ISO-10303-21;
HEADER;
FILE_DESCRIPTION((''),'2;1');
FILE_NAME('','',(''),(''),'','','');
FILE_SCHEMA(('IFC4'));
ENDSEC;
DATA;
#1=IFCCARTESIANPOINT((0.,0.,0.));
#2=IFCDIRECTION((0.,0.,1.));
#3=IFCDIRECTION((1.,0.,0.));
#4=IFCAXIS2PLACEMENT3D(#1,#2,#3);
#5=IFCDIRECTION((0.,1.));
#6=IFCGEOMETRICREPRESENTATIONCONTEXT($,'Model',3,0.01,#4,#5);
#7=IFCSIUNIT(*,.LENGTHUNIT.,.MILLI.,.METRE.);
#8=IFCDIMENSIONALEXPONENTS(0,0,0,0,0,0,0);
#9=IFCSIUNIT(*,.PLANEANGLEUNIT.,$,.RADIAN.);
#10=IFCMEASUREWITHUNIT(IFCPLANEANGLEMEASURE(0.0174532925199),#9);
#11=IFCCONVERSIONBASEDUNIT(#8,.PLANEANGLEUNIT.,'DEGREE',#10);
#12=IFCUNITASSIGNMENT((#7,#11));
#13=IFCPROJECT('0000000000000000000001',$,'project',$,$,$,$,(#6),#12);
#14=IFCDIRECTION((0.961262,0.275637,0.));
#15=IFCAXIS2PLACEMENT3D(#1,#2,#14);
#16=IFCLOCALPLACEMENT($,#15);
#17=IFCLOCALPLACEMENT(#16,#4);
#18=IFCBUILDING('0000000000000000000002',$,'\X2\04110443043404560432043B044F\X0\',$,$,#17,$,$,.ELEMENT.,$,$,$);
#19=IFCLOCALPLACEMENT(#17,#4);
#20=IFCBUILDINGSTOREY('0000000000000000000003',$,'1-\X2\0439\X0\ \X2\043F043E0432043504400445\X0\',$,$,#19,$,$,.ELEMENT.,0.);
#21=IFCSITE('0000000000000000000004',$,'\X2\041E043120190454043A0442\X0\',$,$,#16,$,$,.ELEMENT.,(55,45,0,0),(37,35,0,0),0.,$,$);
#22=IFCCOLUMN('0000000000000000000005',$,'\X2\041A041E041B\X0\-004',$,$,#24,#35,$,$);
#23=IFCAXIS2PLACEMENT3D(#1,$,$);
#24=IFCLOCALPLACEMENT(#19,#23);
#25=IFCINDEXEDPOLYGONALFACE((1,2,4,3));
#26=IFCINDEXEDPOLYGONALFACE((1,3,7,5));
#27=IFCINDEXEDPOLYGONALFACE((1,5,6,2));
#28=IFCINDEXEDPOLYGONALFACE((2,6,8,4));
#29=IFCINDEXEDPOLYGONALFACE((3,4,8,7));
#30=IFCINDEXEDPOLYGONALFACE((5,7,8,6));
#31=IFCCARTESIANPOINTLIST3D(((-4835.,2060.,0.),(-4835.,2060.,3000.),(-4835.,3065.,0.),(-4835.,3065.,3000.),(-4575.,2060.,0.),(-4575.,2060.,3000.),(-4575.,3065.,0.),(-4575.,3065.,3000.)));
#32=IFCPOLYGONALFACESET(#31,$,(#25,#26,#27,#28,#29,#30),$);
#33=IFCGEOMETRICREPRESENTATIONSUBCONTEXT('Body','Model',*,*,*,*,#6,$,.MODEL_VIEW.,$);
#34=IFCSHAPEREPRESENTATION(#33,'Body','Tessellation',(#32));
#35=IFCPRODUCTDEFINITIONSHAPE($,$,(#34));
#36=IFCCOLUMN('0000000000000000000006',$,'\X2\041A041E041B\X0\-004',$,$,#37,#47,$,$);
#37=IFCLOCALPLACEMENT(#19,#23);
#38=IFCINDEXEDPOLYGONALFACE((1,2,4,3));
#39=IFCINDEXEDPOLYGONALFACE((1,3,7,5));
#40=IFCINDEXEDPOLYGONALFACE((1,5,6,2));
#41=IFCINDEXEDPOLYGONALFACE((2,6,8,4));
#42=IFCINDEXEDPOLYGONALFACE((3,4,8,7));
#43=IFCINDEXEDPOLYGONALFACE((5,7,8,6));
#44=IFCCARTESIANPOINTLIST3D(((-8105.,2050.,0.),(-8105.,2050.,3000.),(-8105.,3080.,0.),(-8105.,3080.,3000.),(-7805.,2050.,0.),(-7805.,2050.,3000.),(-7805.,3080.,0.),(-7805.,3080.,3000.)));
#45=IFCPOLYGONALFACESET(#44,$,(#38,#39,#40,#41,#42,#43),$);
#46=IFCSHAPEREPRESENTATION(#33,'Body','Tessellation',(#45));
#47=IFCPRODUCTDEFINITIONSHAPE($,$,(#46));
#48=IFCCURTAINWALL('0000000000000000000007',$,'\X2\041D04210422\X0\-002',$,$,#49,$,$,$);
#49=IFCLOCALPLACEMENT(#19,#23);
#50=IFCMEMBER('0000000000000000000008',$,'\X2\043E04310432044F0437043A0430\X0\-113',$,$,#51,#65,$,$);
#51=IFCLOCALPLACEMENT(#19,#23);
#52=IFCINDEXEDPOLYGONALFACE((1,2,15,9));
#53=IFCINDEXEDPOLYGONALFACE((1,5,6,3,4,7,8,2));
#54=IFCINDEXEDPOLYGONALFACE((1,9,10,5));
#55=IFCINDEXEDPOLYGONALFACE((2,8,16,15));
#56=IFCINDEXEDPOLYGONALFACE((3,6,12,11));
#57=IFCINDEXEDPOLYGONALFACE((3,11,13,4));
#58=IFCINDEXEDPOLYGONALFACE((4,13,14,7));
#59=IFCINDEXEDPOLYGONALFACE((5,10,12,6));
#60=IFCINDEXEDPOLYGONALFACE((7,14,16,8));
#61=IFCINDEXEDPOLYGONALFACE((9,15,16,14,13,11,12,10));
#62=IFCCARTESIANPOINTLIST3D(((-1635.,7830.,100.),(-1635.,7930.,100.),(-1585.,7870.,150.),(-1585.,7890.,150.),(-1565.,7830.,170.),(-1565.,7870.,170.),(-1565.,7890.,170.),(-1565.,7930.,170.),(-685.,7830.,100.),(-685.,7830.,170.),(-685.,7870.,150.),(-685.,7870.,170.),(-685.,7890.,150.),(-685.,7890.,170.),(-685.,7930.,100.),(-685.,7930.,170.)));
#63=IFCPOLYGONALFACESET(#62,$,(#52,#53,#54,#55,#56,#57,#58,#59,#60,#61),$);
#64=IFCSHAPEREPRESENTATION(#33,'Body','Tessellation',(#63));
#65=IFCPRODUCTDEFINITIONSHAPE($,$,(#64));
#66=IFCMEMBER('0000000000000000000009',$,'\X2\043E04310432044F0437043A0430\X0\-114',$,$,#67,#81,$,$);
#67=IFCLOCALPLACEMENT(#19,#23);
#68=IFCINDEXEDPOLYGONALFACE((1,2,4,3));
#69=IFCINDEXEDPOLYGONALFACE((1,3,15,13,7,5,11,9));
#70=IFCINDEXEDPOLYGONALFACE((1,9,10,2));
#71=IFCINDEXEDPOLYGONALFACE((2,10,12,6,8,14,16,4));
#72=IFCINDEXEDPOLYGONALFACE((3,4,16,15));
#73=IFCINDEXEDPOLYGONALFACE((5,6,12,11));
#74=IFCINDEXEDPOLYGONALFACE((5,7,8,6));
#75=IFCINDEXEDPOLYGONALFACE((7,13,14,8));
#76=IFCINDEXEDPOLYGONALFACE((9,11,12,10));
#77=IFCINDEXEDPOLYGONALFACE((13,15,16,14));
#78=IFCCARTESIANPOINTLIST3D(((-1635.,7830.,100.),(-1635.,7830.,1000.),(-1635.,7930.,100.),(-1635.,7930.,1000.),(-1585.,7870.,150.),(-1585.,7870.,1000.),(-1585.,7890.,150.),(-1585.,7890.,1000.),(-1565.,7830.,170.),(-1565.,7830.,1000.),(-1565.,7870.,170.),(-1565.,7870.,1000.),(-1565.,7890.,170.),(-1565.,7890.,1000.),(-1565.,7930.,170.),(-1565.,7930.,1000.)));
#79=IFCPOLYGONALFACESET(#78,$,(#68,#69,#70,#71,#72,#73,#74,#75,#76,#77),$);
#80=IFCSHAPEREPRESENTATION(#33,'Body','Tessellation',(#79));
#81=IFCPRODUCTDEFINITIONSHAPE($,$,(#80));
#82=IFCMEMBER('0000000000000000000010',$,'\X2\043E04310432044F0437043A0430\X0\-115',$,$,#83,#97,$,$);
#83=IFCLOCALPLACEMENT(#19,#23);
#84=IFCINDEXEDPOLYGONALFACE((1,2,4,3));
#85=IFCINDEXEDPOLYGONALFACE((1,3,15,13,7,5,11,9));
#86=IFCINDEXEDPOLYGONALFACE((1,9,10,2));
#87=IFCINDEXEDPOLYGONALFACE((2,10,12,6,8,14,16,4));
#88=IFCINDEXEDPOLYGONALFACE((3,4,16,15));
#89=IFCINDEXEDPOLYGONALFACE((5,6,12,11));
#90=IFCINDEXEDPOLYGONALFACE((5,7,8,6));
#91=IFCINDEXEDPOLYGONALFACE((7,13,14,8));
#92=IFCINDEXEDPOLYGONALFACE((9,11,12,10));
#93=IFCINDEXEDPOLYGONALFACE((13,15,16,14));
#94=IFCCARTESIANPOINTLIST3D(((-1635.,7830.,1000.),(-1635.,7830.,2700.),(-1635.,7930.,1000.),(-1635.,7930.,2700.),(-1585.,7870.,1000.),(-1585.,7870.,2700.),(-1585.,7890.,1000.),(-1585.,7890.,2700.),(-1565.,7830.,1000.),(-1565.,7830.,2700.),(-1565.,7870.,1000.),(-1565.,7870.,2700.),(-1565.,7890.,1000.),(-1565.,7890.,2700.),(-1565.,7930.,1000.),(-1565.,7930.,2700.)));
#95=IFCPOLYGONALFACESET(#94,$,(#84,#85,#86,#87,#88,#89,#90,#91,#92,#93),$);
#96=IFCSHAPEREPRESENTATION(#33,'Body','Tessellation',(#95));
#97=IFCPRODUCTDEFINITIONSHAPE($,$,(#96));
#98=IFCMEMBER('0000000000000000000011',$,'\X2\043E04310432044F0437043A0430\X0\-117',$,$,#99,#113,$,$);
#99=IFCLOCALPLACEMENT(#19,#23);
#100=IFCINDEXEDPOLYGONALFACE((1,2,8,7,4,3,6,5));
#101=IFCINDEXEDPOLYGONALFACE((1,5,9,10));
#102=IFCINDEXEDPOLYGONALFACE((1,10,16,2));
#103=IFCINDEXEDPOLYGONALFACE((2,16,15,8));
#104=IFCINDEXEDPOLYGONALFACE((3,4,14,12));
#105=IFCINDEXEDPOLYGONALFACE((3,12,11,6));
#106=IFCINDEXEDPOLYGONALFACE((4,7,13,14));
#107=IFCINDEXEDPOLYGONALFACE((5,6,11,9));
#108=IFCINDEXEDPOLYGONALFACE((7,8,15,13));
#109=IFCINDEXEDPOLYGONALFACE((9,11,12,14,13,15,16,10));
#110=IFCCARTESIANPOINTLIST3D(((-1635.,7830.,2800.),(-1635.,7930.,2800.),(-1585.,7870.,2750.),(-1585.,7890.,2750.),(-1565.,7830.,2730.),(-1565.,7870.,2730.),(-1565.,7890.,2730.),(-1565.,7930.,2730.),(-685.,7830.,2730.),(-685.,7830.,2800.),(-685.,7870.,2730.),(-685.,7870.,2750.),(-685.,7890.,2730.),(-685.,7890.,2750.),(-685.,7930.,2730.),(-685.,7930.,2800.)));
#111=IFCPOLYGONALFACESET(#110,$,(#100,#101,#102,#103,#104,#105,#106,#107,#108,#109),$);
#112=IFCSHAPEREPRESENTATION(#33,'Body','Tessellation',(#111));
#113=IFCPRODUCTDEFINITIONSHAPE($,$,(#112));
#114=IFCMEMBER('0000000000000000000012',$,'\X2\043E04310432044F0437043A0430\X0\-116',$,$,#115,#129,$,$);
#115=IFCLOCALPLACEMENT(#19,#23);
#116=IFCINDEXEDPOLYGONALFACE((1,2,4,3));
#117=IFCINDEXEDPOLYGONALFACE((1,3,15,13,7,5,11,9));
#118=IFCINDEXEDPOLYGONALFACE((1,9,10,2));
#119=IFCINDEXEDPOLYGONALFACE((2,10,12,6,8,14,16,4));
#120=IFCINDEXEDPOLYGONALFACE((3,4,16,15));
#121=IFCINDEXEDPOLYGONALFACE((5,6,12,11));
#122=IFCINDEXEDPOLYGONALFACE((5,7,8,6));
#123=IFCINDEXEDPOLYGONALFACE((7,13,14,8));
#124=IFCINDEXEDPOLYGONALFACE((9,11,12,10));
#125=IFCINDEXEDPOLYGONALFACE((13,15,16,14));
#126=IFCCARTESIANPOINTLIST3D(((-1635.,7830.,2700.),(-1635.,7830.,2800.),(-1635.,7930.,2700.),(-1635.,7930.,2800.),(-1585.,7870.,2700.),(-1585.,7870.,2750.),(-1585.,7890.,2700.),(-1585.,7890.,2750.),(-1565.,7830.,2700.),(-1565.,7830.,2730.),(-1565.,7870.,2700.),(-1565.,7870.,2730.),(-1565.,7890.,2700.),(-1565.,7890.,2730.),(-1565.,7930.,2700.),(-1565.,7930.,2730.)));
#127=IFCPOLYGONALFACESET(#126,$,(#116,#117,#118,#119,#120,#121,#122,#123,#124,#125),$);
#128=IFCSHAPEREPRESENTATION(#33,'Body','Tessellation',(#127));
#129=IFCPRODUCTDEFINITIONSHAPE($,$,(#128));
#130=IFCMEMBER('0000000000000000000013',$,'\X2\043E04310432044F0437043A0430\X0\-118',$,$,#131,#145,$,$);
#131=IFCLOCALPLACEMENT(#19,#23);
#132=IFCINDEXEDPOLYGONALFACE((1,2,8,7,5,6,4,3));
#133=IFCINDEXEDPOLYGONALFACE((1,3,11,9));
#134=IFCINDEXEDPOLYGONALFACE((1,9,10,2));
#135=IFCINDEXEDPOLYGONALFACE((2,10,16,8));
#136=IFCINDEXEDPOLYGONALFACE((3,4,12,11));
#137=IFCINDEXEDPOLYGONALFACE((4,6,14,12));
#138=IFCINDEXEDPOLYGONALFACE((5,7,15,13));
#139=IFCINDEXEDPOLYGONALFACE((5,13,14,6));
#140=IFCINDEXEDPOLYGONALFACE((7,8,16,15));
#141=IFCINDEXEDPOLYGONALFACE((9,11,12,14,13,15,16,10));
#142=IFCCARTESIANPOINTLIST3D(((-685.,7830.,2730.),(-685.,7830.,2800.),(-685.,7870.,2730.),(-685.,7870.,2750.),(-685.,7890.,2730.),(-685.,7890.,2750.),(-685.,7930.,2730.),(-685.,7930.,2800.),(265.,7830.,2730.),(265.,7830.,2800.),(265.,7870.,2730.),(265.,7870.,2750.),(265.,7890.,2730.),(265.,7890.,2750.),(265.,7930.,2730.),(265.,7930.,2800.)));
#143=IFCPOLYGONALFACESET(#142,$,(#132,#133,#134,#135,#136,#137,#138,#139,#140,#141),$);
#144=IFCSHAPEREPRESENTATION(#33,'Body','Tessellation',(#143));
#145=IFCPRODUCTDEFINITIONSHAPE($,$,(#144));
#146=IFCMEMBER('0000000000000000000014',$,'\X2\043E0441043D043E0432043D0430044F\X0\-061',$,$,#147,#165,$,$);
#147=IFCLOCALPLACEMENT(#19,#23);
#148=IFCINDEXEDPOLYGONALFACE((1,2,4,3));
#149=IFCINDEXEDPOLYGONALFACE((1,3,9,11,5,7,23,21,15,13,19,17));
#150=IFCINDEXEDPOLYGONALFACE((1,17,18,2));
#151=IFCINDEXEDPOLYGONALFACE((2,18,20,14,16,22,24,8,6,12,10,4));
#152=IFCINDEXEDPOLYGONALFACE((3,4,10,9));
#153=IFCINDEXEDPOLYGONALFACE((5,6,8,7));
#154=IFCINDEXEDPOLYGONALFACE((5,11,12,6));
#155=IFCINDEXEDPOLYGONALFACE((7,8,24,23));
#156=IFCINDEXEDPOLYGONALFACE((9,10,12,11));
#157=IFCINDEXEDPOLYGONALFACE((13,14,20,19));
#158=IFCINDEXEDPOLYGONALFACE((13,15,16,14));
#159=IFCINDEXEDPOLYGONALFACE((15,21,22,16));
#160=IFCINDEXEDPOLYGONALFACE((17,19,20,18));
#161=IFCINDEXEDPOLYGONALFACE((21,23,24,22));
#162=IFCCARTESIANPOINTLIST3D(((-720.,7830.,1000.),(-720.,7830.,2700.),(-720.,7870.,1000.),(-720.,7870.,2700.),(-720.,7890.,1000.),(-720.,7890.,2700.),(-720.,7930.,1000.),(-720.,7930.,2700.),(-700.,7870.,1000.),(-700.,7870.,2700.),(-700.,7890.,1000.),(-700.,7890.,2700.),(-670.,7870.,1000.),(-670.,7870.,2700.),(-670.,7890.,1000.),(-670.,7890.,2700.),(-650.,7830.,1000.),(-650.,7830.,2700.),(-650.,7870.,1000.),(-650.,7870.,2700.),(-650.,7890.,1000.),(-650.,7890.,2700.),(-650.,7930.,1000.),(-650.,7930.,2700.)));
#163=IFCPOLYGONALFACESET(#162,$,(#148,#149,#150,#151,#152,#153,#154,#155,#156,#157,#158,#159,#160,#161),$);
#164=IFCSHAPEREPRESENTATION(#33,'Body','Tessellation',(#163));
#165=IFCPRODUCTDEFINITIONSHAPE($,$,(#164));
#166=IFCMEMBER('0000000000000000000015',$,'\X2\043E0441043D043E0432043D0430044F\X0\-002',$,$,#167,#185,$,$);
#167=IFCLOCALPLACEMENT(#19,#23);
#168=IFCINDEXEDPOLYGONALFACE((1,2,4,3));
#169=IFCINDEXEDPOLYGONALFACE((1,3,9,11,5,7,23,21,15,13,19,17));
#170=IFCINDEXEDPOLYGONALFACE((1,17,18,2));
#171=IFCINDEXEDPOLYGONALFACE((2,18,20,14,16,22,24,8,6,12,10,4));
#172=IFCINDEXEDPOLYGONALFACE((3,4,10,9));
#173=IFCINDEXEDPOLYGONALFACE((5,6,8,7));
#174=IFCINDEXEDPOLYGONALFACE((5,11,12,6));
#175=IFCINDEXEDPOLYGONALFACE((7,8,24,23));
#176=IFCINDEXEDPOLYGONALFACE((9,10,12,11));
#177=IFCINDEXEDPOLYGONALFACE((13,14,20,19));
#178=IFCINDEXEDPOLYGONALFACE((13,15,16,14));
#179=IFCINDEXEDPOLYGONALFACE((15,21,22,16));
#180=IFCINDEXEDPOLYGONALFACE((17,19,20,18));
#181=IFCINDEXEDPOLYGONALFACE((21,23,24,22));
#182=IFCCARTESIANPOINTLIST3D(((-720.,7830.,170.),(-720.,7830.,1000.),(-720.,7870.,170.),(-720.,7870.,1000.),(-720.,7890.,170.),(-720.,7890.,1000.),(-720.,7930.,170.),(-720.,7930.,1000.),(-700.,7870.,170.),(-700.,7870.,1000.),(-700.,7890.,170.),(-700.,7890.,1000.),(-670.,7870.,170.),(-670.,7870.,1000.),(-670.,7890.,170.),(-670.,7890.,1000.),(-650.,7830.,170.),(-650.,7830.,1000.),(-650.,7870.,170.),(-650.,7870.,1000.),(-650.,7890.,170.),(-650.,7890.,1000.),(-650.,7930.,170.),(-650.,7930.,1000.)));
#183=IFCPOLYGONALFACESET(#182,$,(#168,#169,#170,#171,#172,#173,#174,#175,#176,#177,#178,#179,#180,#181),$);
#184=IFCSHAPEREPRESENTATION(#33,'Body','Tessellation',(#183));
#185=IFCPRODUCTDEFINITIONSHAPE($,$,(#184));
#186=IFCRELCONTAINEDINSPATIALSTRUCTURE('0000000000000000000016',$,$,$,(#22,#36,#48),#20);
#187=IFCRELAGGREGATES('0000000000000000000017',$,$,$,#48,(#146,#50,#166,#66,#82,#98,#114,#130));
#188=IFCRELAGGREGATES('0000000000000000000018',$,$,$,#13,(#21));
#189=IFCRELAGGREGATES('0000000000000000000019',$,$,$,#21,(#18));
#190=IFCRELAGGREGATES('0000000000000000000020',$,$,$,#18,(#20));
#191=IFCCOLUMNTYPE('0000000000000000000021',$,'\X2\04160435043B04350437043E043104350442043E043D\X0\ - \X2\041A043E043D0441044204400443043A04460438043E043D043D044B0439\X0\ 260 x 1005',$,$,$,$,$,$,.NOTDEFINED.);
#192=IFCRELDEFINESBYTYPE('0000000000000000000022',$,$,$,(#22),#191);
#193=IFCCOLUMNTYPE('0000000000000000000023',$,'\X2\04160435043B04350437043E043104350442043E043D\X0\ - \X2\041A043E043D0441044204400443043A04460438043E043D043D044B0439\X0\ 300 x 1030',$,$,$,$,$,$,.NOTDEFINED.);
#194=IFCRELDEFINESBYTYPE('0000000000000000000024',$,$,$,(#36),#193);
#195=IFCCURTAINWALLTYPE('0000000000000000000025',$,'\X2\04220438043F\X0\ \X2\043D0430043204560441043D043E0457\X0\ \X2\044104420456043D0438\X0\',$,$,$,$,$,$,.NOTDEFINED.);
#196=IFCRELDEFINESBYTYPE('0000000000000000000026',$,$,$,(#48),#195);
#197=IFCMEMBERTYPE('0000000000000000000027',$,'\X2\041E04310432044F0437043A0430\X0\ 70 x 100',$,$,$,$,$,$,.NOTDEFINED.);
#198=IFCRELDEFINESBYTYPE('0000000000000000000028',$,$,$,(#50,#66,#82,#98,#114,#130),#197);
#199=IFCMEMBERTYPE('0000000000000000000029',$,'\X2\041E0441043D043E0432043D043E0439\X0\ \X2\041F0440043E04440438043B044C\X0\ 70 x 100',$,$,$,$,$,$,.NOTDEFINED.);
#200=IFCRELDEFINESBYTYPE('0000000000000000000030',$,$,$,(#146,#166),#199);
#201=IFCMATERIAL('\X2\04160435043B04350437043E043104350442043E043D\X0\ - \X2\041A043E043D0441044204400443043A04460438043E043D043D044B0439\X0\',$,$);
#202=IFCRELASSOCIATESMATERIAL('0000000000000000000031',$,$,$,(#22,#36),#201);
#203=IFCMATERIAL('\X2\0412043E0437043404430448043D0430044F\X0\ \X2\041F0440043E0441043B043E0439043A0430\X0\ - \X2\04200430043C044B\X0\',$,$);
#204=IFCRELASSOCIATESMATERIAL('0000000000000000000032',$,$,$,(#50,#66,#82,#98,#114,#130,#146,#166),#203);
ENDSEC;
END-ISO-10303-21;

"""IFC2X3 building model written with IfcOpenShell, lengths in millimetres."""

from ifc_helpers import new_model, entity, si_unit, converted_unit, direction, frame, origin_with_axes, origin_2d_with_axis, place, context, subcontext, project, spatial, polyline, rectangle, outline, extrude, clip, halfspace, material, type_object, element, aggregate, save


model = new_model("IFC2X3")

# Units and contexts
model_context = context("Model", 3, precision=0.01, world=origin_with_axes(), true_north=direction((0.0, 1.0)))
body_context = subcontext(model_context, "Body", "Model", "MODEL_VIEW")
ifc_project = project(units=[si_unit("LENGTHUNIT", "METRE", prefix="MILLI"), converted_unit("PLANEANGLEUNIT", "DEGREE", entity("IfcPlaneAngleMeasure", 0.0174532925199), si_unit("PLANEANGLEUNIT", "RADIAN"), dimensions=[0, 0, 0, 0, 0, 0, 0])], contexts=[model_context])

# Site, building, storey
site_placement = place(None, frame((0.0, 0.0, 0.0), z_axis=(0.0, 0.0, 1.0), x_axis=(0.961262, 0.275637, 0.0)))
site = spatial("IfcSite", under=ifc_project, at=site_placement, Name="Об’єкт", CompositionType="ELEMENT", RefLatitude=(55, 45, 0, 0), RefLongitude=(37, 35, 0, 0), RefElevation=0.0)
building_placement = place(site_placement, origin_with_axes())
building = spatial("IfcBuilding", under=site, at=building_placement, Name="Будівля", CompositionType="ELEMENT")
storey_placement = place(building_placement, origin_with_axes())
storey = spatial("IfcBuildingStorey", under=building, at=storey_placement, Name="1-й поверх", CompositionType="ELEMENT", Elevation=0.0)

# Columns
ifc_material_1 = material(Name="Железобетон - Конструкционный")
column_type_1 = type_object("IfcColumnType", Name="Железобетон - Конструкционный 260 x 1005", PredefinedType="NOTDEFINED")
column_1_placement = place(storey_placement, frame((-4705.0, 2562.5, 0.0), z_axis=(0.0, 0.0, 1.0), x_axis=(1.0, 0.0, 0.0)))
element("IfcColumn", 1, at=column_1_placement, inside=storey, type_object=column_type_1, material=ifc_material_1, Name="КОЛ-004", context=body_context, shape_type="SweptSolid", body=[
    extrude(rectangle(XDim=260.0, YDim=1005.0, at=origin_2d_with_axis()), origin_with_axes(), (0.0, 0.0, 1.0), 3000.0),
])
column_type_2 = type_object("IfcColumnType", Name="Железобетон - Конструкционный 300 x 1030", PredefinedType="NOTDEFINED")
column_2_placement = place(storey_placement, frame((-7955.0, 2565.0, 0.0), z_axis=(0.0, 0.0, 1.0), x_axis=(1.0, 0.0, 0.0)))
element("IfcColumn", 2, at=column_2_placement, inside=storey, type_object=column_type_2, material=ifc_material_1, Name="КОЛ-004", context=body_context, shape_type="SweptSolid", body=[
    extrude(rectangle(XDim=300.0, YDim=1030.0, at=origin_2d_with_axis()), origin_with_axes(), (0.0, 0.0, 1.0), 3000.0),
])

# Curtain wall, members
curtain_wall_type = type_object("IfcCurtainWallType", Name="Тип навісної стіни", PredefinedType="NOTDEFINED")
curtain_wall_placement = place(storey_placement, frame((-210.0, 7880.0, 100.0), z_axis=(0.0, 0.0, 1.0), x_axis=(1.0, 0.0, 0.0)))
curtain_wall = element("IfcCurtainWall", 3, at=curtain_wall_placement, inside=storey, type_object=curtain_wall_type, Name="НСТ-002")
ifc_material_2 = material(Name="Воздушная Прослойка - Рамы")
member_type_1 = type_object("IfcMemberType", Name="Обвязка 70 x 100", PredefinedType="NOTDEFINED")
member_1_placement = place(curtain_wall_placement, frame((-475.0, 0.0, 0.0), z_axis=(-1.0, 0.0, 0.0), x_axis=(0.0, 0.0, 1.0)))
member_1 = element("IfcMember", 4, at=member_1_placement, type_object=member_type_1, material=ifc_material_2, Name="обвязка-113", context=body_context, shape_type="Clipping", body=[
    clip(extrude(outline(polyline([(-10.0, -50.0), (10.0, -50.0), (10.0, -70.0), (50.0, -70.0), (50.0, 0.0), (-50.0, 0.0), (-50.0, -70.0), (-10.0, -70.0), (-10.0, -50.0)])), frame((0.0, 0.0, 0.0), z_axis=(0.0, 0.0, 1.0), x_axis=(0.0, 1.0, 0.0)), (0.0, 0.0, 1.0), 950.0), halfspace(frame((475.0, 0.0, 475.0), z_axis=(-0.707107, 0.0, -0.707107), x_axis=(0.0, 1.0, 0.0)), True)),
])
member_2_placement = place(curtain_wall_placement, frame((-1425.0, 0.0, 0.0), z_axis=(0.0, 0.0, 1.0), x_axis=(1.0, 0.0, 0.0)))
member_2 = element("IfcMember", 5, at=member_2_placement, type_object=member_type_1, material=ifc_material_2, Name="обвязка-114", context=body_context, shape_type="Clipping", body=[
    clip(extrude(outline(polyline([(50.0, -10.0), (50.0, 10.0), (70.0, 10.0), (70.0, 50.0), (0.0, 50.0), (0.0, -50.0), (70.0, -50.0), (70.0, -10.0), (50.0, -10.0)])), origin_with_axes(), (0.0, 0.0, 1.0), 900.0), halfspace(frame((0.0, 0.0, 0.0), z_axis=(-0.707107, 0.0, 0.707107), x_axis=(0.0, -1.0, 0.0)), True)),
])
member_3_placement = place(curtain_wall_placement, frame((-1425.0, 0.0, 900.0), z_axis=(0.0, 0.0, 1.0), x_axis=(1.0, 0.0, 0.0)))
member_3 = element("IfcMember", 6, at=member_3_placement, type_object=member_type_1, material=ifc_material_2, Name="обвязка-115", context=body_context, shape_type="SweptSolid", body=[
    extrude(outline(polyline([(50.0, -10.0), (50.0, 10.0), (70.0, 10.0), (70.0, 50.0), (0.0, 50.0), (0.0, -50.0), (70.0, -50.0), (70.0, -10.0), (50.0, -10.0)])), frame((0.0, 0.0, 0.0), z_axis=(0.0, 0.0, 1.0), x_axis=(1.0, 0.0, 0.0)), (0.0, 0.0, 1.0), 1700.0),
])
member_4_placement = place(curtain_wall_placement, frame((-1425.0, 0.0, 2700.0), z_axis=(1.0, 0.0, 0.0), x_axis=(0.0, 0.0, -1.0)))
member_4 = element("IfcMember", 7, at=member_4_placement, type_object=member_type_1, material=ifc_material_2, Name="обвязка-117", context=body_context, shape_type="Clipping", body=[
    clip(extrude(outline(polyline([(10.0, 50.0), (-10.0, 50.0), (-10.0, 70.0), (-50.0, 70.0), (-50.0, 0.0), (50.0, 0.0), (50.0, 70.0), (10.0, 70.0), (10.0, 50.0)])), frame((0.0, 0.0, 0.0), z_axis=(0.0, 0.0, 1.0), x_axis=(0.0, -1.0, 0.0)), (0.0, 0.0, 1.0), 950.0), halfspace(frame((0.0, 0.0, 0.0), z_axis=(-0.707107, 0.0, 0.707107), x_axis=(0.0, -1.0, 0.0)), True)),
])
member_5_placement = place(curtain_wall_placement, frame((-1425.0, 0.0, 2600.0), z_axis=(0.0, 0.0, 1.0), x_axis=(1.0, 0.0, 0.0)))
member_5 = element("IfcMember", 8, at=member_5_placement, type_object=member_type_1, material=ifc_material_2, Name="обвязка-116", context=body_context, shape_type="Clipping", body=[
    clip(extrude(outline(polyline([(50.0, -10.0), (50.0, 10.0), (70.0, 10.0), (70.0, 50.0), (0.0, 50.0), (0.0, -50.0), (70.0, -50.0), (70.0, -10.0), (50.0, -10.0)])), origin_with_axes(), (0.0, 0.0, 1.0), 100.0), halfspace(frame((50.0, 0.0, 50.0), z_axis=(-0.707107, 0.0, -0.707107), x_axis=(0.0, 1.0, 0.0)), True)),
])
member_6_placement = place(curtain_wall_placement, frame((-475.0, 0.0, 2700.0), z_axis=(1.0, 0.0, 0.0), x_axis=(0.0, 0.0, -1.0)))
member_6 = element("IfcMember", 9, at=member_6_placement, type_object=member_type_1, material=ifc_material_2, Name="обвязка-118", context=body_context, shape_type="SweptSolid", body=[
    extrude(outline(polyline([(10.0, 50.0), (-10.0, 50.0), (-10.0, 70.0), (-50.0, 70.0), (-50.0, 0.0), (50.0, 0.0), (50.0, 70.0), (10.0, 70.0), (10.0, 50.0)])), frame((0.0, 0.0, 0.0), z_axis=(0.0, 0.0, 1.0), x_axis=(0.0, -1.0, 0.0)), (0.0, 0.0, 1.0), 950.0),
])
member_type_2 = type_object("IfcMemberType", Name="Основной Профиль 70 x 100", PredefinedType="NOTDEFINED")
member_7_placement = place(curtain_wall_placement, frame((-475.0, 0.0, 900.0), z_axis=(0.0, 0.0, 1.0), x_axis=(1.0, 0.0, 0.0)))
member_7 = element("IfcMember", 10, at=member_7_placement, type_object=member_type_2, material=ifc_material_2, Name="основная-061", context=body_context, shape_type="SweptSolid", body=[
    extrude(outline(polyline([(-15.0, -10.0), (-35.0, -10.0), (-35.0, -50.0), (35.0, -50.0), (35.0, -10.0), (15.0, -10.0), (15.0, 10.0), (35.0, 10.0), (35.0, 50.0), (-35.0, 50.0), (-35.0, 10.0), (-15.0, 10.0), (-15.0, -10.0)])), origin_with_axes(), (0.0, 0.0, 1.0), 1700.0),
])
member_8_placement = place(curtain_wall_placement, frame((-475.0, 0.0, 0.0), z_axis=(0.0, 0.0, 1.0), x_axis=(1.0, 0.0, 0.0)))
member_8 = element("IfcMember", 11, at=member_8_placement, type_object=member_type_2, material=ifc_material_2, Name="основная-002", context=body_context, shape_type="SweptSolid", body=[
    extrude(outline(polyline([(-15.0, -10.0), (-35.0, -10.0), (-35.0, -50.0), (35.0, -50.0), (35.0, -10.0), (15.0, -10.0), (15.0, 10.0), (35.0, 10.0), (35.0, 50.0), (-35.0, 50.0), (-35.0, 10.0), (-15.0, 10.0), (-15.0, -10.0)])), frame((0.0, 0.0, 70.0), z_axis=(0.0, 0.0, 1.0), x_axis=(1.0, 0.0, 0.0)), (0.0, 0.0, 1.0), 830.0),
])

aggregate(curtain_wall, [member_7, member_1, member_8, member_2, member_3, member_4, member_5, member_6])

save(model, "model.ifc")
